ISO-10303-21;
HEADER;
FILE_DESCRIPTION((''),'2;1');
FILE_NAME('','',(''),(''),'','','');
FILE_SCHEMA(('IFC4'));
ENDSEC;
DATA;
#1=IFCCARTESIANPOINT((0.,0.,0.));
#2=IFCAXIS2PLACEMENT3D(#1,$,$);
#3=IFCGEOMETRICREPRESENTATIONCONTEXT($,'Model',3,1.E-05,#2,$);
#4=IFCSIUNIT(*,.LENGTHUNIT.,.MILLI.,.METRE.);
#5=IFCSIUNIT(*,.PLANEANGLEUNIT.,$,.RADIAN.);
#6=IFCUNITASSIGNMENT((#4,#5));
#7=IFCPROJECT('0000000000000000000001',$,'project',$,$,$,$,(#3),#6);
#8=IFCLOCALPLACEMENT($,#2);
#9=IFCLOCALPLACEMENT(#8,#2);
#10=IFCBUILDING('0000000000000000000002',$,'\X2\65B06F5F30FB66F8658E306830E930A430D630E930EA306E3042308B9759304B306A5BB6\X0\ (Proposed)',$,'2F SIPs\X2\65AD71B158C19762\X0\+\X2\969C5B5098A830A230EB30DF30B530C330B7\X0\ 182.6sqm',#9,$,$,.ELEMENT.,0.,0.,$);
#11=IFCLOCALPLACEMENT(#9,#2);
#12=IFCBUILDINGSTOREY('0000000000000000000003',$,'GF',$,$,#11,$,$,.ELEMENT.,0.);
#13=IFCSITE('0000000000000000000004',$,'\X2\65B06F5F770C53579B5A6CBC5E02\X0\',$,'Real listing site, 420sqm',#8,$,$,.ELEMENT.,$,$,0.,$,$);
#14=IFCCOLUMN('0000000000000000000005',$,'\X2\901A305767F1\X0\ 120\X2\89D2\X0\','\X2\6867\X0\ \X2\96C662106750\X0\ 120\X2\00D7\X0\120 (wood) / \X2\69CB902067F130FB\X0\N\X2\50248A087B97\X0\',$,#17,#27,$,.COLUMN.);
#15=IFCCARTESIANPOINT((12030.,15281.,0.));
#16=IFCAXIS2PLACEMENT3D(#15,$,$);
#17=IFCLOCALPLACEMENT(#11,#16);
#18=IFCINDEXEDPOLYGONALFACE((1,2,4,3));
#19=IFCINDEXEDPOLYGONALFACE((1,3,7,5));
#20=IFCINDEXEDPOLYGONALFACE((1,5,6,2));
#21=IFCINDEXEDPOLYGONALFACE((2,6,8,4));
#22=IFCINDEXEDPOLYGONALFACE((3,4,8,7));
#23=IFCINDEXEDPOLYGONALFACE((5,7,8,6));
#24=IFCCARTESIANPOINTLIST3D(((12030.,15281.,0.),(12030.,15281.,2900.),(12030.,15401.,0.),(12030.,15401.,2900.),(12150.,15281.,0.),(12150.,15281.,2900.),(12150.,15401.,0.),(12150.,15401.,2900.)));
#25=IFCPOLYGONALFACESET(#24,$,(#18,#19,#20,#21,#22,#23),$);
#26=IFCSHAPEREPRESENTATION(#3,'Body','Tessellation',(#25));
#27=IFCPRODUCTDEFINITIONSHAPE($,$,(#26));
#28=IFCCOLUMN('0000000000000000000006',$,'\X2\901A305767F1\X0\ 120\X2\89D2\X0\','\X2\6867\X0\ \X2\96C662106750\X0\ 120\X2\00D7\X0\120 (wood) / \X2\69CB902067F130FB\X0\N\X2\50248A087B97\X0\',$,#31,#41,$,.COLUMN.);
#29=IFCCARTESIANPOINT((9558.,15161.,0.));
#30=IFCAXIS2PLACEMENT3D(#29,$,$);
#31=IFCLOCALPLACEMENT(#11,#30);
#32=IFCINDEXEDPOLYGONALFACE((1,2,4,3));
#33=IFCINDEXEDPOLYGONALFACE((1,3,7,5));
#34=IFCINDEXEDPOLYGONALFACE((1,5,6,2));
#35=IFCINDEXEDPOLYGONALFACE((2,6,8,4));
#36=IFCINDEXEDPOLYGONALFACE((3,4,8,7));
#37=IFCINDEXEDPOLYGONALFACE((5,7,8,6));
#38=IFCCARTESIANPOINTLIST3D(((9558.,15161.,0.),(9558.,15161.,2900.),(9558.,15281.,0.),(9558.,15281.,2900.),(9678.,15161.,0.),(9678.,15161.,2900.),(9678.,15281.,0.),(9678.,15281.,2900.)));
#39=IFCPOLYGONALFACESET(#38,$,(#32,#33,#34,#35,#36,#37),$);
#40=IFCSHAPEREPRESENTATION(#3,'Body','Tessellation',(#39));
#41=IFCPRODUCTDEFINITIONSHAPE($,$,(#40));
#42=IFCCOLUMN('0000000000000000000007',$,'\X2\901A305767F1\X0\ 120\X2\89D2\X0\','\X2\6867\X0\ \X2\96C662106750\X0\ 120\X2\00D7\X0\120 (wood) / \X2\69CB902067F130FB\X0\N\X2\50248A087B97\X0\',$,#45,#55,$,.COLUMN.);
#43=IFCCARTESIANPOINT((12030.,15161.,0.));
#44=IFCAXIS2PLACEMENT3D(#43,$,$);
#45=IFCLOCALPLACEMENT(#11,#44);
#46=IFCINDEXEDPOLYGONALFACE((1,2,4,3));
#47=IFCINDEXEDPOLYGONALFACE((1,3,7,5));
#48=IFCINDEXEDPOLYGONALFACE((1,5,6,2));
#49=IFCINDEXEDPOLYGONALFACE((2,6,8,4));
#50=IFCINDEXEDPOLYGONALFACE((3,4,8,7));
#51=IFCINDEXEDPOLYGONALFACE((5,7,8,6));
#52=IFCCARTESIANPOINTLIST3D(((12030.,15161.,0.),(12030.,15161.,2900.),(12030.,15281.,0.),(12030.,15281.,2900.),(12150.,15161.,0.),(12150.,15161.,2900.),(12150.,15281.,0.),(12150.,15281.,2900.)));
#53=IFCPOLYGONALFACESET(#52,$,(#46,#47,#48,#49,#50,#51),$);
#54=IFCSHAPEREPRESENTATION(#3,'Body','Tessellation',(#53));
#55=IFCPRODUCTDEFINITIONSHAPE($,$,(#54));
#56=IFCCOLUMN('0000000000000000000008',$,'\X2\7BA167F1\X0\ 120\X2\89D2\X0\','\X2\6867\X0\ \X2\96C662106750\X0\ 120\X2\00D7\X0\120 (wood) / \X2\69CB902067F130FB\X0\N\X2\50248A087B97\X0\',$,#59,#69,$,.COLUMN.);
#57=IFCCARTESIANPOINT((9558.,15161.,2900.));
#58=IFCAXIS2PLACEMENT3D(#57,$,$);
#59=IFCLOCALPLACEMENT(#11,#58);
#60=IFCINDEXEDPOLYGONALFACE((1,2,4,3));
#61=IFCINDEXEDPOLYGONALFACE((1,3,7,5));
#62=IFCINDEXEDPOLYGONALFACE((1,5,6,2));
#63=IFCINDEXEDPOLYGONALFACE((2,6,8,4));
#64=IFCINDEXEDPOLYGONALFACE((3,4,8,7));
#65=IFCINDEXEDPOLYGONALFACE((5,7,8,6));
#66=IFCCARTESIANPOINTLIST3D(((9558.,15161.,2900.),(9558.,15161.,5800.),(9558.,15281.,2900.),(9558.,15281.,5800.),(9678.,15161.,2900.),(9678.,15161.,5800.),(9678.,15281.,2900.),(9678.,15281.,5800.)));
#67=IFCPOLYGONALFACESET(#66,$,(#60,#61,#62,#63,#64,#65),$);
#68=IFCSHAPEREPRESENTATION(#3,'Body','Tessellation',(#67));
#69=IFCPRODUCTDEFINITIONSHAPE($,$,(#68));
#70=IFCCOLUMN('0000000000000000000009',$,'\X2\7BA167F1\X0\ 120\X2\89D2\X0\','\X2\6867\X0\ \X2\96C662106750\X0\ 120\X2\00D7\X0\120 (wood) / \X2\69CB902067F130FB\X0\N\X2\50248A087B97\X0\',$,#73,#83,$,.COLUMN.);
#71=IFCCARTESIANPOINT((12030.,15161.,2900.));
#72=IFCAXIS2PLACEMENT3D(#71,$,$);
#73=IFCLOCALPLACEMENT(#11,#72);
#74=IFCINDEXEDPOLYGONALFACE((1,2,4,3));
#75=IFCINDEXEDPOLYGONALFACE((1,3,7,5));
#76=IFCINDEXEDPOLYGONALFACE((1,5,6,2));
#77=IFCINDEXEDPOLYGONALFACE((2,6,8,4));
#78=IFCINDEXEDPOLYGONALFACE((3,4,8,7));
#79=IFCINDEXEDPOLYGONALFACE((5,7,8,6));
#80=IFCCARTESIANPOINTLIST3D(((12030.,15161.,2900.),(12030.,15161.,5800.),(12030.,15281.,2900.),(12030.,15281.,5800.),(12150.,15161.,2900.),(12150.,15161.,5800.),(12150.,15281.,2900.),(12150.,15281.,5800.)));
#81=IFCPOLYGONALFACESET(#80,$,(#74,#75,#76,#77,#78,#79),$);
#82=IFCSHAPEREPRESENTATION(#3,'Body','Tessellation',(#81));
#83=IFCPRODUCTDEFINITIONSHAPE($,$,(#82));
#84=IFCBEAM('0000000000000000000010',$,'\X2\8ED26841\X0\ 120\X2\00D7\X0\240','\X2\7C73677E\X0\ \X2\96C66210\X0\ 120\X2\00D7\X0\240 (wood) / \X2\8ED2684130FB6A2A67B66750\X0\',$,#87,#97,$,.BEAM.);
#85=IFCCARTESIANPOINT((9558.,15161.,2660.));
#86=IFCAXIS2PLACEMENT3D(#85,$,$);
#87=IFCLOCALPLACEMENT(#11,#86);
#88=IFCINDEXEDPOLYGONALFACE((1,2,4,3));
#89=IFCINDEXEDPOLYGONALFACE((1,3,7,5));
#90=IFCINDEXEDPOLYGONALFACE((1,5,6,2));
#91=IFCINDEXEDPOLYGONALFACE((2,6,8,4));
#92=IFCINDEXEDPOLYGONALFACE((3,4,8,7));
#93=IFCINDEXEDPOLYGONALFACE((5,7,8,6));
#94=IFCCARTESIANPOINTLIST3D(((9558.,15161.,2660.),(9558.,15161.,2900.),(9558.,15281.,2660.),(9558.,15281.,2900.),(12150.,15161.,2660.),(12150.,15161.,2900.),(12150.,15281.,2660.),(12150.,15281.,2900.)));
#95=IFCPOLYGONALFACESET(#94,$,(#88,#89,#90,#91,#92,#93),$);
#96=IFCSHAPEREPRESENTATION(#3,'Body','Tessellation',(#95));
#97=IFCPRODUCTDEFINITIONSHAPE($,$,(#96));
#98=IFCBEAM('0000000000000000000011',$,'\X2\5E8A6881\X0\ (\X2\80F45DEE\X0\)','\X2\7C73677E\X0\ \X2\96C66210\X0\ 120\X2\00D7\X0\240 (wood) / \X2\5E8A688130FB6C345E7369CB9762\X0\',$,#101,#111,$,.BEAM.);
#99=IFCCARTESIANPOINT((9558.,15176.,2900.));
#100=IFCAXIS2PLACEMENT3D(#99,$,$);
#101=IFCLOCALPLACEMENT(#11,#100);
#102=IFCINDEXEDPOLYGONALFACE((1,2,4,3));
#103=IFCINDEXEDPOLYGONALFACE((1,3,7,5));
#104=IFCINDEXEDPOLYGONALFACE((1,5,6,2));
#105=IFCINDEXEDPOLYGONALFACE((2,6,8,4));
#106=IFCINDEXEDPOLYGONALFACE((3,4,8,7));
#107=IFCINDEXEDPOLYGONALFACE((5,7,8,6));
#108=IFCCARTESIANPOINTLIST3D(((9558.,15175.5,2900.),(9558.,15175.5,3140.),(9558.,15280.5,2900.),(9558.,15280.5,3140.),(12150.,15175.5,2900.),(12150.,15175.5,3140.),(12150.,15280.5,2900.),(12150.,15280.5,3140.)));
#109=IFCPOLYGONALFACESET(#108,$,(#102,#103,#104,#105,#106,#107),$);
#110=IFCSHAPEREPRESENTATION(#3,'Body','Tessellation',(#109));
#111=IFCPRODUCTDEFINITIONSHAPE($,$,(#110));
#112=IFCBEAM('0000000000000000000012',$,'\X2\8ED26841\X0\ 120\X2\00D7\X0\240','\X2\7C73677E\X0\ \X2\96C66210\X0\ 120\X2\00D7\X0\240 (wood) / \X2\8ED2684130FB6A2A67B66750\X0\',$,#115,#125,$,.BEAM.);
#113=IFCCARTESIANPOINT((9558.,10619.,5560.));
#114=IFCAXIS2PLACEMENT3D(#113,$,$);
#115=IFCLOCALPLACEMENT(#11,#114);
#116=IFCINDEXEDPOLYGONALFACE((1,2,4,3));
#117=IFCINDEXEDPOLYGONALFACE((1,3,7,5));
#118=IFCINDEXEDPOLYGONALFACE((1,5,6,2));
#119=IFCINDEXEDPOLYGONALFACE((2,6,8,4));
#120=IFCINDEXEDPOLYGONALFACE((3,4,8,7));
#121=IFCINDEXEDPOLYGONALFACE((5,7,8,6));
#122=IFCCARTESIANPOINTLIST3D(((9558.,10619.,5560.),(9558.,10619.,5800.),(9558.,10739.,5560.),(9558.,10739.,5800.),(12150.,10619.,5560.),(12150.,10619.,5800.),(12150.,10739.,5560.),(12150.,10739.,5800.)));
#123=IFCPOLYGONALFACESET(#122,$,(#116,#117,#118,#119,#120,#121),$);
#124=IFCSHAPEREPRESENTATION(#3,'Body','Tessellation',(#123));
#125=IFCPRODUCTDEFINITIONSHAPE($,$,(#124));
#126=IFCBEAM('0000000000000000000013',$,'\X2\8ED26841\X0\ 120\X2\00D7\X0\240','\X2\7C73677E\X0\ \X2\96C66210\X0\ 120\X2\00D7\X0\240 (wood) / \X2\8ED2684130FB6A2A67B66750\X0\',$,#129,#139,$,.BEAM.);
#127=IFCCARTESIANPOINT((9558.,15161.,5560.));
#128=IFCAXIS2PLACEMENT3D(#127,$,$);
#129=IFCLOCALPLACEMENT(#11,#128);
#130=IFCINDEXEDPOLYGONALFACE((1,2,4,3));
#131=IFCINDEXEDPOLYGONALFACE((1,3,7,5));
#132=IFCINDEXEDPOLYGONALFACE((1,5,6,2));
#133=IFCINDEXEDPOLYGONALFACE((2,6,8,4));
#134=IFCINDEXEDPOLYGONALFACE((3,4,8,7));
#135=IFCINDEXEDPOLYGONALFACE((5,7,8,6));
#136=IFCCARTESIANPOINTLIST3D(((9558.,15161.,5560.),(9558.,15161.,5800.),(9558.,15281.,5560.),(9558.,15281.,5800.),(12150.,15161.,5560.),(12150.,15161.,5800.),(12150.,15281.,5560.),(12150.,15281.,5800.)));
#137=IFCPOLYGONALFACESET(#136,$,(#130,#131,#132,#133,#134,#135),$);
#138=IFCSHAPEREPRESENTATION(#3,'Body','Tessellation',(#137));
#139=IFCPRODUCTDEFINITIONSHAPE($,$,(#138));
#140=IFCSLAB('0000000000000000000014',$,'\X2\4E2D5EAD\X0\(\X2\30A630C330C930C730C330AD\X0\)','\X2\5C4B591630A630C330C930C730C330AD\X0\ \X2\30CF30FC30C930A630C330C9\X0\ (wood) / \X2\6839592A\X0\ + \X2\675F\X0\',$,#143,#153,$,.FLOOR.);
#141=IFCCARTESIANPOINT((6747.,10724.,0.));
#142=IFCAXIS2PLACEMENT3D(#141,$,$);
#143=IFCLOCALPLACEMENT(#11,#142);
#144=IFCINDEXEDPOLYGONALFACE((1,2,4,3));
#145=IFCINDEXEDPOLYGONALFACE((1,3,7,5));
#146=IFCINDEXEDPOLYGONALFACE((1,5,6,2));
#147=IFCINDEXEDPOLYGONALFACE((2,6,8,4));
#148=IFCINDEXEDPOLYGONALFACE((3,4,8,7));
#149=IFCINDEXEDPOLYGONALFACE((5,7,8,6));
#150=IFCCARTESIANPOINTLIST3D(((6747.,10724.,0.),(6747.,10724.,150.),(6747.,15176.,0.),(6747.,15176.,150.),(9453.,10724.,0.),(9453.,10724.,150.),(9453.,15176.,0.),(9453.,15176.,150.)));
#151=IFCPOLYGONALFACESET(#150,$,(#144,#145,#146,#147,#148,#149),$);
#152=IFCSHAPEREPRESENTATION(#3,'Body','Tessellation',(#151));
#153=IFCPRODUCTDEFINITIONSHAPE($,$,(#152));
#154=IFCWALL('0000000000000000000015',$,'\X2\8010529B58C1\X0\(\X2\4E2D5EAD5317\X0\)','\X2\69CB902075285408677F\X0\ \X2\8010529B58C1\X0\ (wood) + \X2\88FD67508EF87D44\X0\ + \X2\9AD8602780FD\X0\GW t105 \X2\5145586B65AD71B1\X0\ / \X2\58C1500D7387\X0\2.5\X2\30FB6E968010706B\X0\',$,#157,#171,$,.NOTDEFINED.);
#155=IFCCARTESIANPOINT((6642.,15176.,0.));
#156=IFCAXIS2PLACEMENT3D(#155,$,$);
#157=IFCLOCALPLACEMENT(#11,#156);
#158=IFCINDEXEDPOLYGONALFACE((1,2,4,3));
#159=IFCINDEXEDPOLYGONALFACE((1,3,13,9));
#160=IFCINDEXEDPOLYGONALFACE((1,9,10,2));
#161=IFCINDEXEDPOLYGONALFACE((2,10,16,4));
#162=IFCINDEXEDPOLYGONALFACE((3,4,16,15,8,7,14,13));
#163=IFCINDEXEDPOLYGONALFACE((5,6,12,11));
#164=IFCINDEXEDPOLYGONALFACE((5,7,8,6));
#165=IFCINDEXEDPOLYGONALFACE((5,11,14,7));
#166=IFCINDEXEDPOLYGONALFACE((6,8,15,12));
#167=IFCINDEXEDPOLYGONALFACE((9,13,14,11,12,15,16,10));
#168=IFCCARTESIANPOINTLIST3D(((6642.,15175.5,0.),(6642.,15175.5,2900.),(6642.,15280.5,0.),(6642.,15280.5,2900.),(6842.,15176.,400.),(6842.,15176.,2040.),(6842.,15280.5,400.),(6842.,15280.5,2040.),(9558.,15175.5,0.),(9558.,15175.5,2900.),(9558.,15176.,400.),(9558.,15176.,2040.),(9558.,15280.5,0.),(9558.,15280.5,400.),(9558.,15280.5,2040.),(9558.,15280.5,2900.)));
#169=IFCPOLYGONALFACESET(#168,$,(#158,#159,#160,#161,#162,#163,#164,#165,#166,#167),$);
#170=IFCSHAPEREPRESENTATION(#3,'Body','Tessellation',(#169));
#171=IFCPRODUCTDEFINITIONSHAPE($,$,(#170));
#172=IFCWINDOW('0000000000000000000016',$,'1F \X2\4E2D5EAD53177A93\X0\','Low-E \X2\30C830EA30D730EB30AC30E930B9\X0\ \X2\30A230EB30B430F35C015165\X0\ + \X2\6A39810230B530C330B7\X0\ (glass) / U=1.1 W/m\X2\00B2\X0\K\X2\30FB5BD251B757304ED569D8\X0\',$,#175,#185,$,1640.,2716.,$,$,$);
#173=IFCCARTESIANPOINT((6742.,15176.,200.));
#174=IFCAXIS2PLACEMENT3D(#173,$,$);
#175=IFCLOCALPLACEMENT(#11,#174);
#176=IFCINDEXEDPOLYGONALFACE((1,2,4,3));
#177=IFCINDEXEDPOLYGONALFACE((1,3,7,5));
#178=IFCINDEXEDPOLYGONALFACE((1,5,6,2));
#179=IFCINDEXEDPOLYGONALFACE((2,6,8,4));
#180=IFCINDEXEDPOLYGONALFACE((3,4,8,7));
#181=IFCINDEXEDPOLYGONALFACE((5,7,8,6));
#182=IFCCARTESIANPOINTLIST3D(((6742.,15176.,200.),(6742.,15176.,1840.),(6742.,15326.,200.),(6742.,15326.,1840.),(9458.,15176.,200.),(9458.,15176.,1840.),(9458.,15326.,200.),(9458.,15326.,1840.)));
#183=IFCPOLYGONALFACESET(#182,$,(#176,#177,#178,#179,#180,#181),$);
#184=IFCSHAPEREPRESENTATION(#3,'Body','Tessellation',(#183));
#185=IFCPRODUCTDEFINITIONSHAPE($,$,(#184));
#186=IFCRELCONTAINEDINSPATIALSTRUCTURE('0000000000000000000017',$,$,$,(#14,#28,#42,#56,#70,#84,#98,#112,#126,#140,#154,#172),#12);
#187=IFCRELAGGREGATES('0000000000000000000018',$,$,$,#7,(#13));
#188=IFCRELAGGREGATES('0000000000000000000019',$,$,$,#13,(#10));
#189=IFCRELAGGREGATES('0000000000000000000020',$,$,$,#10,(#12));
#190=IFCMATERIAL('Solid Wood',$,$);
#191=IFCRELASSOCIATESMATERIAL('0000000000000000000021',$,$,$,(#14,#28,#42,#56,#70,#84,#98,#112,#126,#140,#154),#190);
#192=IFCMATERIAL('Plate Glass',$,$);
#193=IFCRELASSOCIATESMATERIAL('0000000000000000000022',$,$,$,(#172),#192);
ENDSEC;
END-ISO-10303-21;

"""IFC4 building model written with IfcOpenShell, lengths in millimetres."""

from ifc_helpers import new_model, si_unit, frame, frame_2d, origin, place, context, project, spatial, rectangle, extrude, material, element, fill, save


model = new_model("IFC4")

# Units and contexts
model_context = context("Model", 3, precision=1e-05, world=origin())
ifc_project = project(units=[si_unit("LENGTHUNIT", "METRE", prefix="MILLI"), si_unit("PLANEANGLEUNIT", "RADIAN")], contexts=[model_context])

# Site, building, storey
site_placement = place(None, origin())
site = spatial("IfcSite", under=ifc_project, at=site_placement, Name="新潟県南魚沼市", ObjectType="Real listing site, 420sqm", CompositionType="ELEMENT", RefElevation=0.0)
building_placement = place(site_placement, origin())
building = spatial("IfcBuilding", under=site, at=building_placement, Name="新潟・書斎とライブラリのある静かな家 (Proposed)", ObjectType="2F SIPs断熱壁面+障子風アルミサッシ 182.6sqm", CompositionType="ELEMENT", ElevationOfRefHeight=0.0, ElevationOfTerrain=0.0)
storey_placement = place(building_placement, origin())
storey = spatial("IfcBuildingStorey", under=building, at=storey_placement, Name="GF", CompositionType="ELEMENT", Elevation=0.0)

# Columns
ifc_material_1 = material(Name="Solid Wood")
column_1_placement = place(storey_placement, frame((12030.0, 15281.0, 0.0)))
element("IfcColumn", 1, at=column_1_placement, inside=storey, material=ifc_material_1, Name="通し柱 120角", Description="桧 集成材 120×120 (wood) / 構造柱・N値計算", PredefinedType="COLUMN", context=model_context, shape_type="SweptSolid", body=[
    extrude(rectangle(XDim=120.0, YDim=120.0, at=frame_2d((60.0, 60.0))), frame((12030.0, 15281.0, 0.0)), (0.0, 0.0, 1.0), 2900.0),
])
column_2_placement = place(storey_placement, frame((9558.0, 15161.0, 0.0)))
element("IfcColumn", 2, at=column_2_placement, inside=storey, material=ifc_material_1, Name="通し柱 120角", Description="桧 集成材 120×120 (wood) / 構造柱・N値計算", PredefinedType="COLUMN", context=model_context, shape_type="SweptSolid", body=[
    extrude(rectangle(XDim=120.0, YDim=120.0, at=frame_2d((60.0, 60.0))), frame((9558.0, 15161.0, 0.0)), (0.0, 0.0, 1.0), 2900.0),
])
column_3_placement = place(storey_placement, frame((12030.0, 15161.0, 0.0)))
element("IfcColumn", 3, at=column_3_placement, inside=storey, material=ifc_material_1, Name="通し柱 120角", Description="桧 集成材 120×120 (wood) / 構造柱・N値計算", PredefinedType="COLUMN", context=model_context, shape_type="SweptSolid", body=[
    extrude(rectangle(XDim=120.0, YDim=120.0, at=frame_2d((60.0, 60.0))), frame((12030.0, 15161.0, 0.0)), (0.0, 0.0, 1.0), 2900.0),
])
column_4_placement = place(storey_placement, frame((9558.0, 15161.0, 2900.0)))
element("IfcColumn", 4, at=column_4_placement, inside=storey, material=ifc_material_1, Name="管柱 120角", Description="桧 集成材 120×120 (wood) / 構造柱・N値計算", PredefinedType="COLUMN", context=model_context, shape_type="SweptSolid", body=[
    extrude(rectangle(XDim=120.0, YDim=120.0, at=frame_2d((60.0, 60.0))), frame((9558.0, 15161.0, 2900.0)), (0.0, 0.0, 1.0), 2900.0),
])
column_5_placement = place(storey_placement, frame((12030.0, 15161.0, 2900.0)))
element("IfcColumn", 5, at=column_5_placement, inside=storey, material=ifc_material_1, Name="管柱 120角", Description="桧 集成材 120×120 (wood) / 構造柱・N値計算", PredefinedType="COLUMN", context=model_context, shape_type="SweptSolid", body=[
    extrude(rectangle(XDim=120.0, YDim=120.0, at=frame_2d((60.0, 60.0))), frame((12030.0, 15161.0, 2900.0)), (0.0, 0.0, 1.0), 2900.0),
])

# Beams
beam_1_placement = place(storey_placement, frame((9558.0, 15161.0, 2660.0)))
element("IfcBeam", 6, at=beam_1_placement, inside=storey, material=ifc_material_1, Name="軒桁 120×240", Description="米松 集成 120×240 (wood) / 軒桁・横架材", PredefinedType="BEAM", context=model_context, shape_type="SweptSolid", body=[
    extrude(rectangle(XDim=2592.0, YDim=120.0, at=frame_2d((1296.0, 60.0))), frame((9558.0, 15161.0, 2660.0)), (0.0, 0.0, 1.0), 240.0),
])
beam_2_placement = place(storey_placement, frame((9558.0, 15176.0, 2900.0)))
element("IfcBeam", 7, at=beam_2_placement, inside=storey, material=ifc_material_1, Name="床梁 (胴差)", Description="米松 集成 120×240 (wood) / 床梁・水平構面", PredefinedType="BEAM", context=model_context, shape_type="SweptSolid", body=[
    extrude(rectangle(XDim=2592.0, YDim=105.0, at=frame_2d((1296.0, 52.0))), frame((9558.0, 15176.0, 2900.0)), (0.0, 0.0, 1.0), 240.0),
])
beam_3_placement = place(storey_placement, frame((9558.0, 10619.0, 5560.0)))
element("IfcBeam", 8, at=beam_3_placement, inside=storey, material=ifc_material_1, Name="軒桁 120×240", Description="米松 集成 120×240 (wood) / 軒桁・横架材", PredefinedType="BEAM", context=model_context, shape_type="SweptSolid", body=[
    extrude(rectangle(XDim=2592.0, YDim=120.0, at=frame_2d((1296.0, 60.0))), frame((9558.0, 10619.0, 5560.0)), (0.0, 0.0, 1.0), 240.0),
])
beam_4_placement = place(storey_placement, frame((9558.0, 15161.0, 5560.0)))
element("IfcBeam", 9, at=beam_4_placement, inside=storey, material=ifc_material_1, Name="軒桁 120×240", Description="米松 集成 120×240 (wood) / 軒桁・横架材", PredefinedType="BEAM", context=model_context, shape_type="SweptSolid", body=[
    extrude(rectangle(XDim=2592.0, YDim=120.0, at=frame_2d((1296.0, 60.0))), frame((9558.0, 15161.0, 5560.0)), (0.0, 0.0, 1.0), 240.0),
])

# Slab
slab_placement = place(storey_placement, frame((6747.0, 10724.0, 0.0)))
element("IfcSlab", 10, at=slab_placement, inside=storey, material=ifc_material_1, Name="中庭(ウッドデッキ)", Description="屋外ウッドデッキ ハードウッド (wood) / 根太 + 束", PredefinedType="FLOOR", context=model_context, shape_type="SweptSolid", body=[
    extrude(rectangle(XDim=2706.0, YDim=4452.0, at=frame_2d((1353.0, 2226.0))), frame((6747.0, 10724.0, 0.0)), (0.0, 0.0, 1.0), 150.0),
])

# Wall, opening, window
wall_1_placement = place(storey_placement, frame((6642.0, 15176.0, 0.0)))
wall_1 = element("IfcWall", 11, at=wall_1_placement, inside=storey, material=ifc_material_1, Name="耐力壁(中庭北)", Description="構造用合板 耐力壁 (wood) + 製材軸組 + 高性能GW t105 充填断熱 / 壁倍率2.5・準耐火", PredefinedType="NOTDEFINED", context=model_context, shape_type="SweptSolid", body=[
    extrude(rectangle(XDim=2916.0, YDim=105.0, at=frame_2d((1458.0, 52.0))), frame((6642.0, 15176.0, 0.0)), (0.0, 0.0, 1.0), 2900.0),
])
opening_1_placement = place(storey_placement, frame((6742.0, 15176.0, 200.0)))
opening_1 = element("IfcOpeningElement", 12, at=opening_1_placement, cuts=wall_1, PredefinedType="NOTDEFINED", context=model_context, shape_type="SweptSolid", body=[
    extrude(rectangle(XDim=2716.0, YDim=150.0, at=frame_2d((1358.0, 75.0))), frame((6742.0, 15176.0, 200.0)), (0.0, 0.0, 1.0), 1640.0),
])
ifc_material_2 = material(Name="Plate Glass")
window_1_placement = place(storey_placement, frame((6742.0, 15176.0, 200.0)))
window_1 = element("IfcWindow", 13, at=window_1_placement, inside=storey, material=ifc_material_2, Name="1F 中庭北窓", Description="Low-E トリプルガラス アルゴン封入 + 樹脂サッシ (glass) / U=1.1 W/m²K・寒冷地仕様", OverallHeight=1640.0, OverallWidth=2716.0, context=model_context, shape_type="SweptSolid", body=[
    extrude(rectangle(XDim=2716.0, YDim=150.0, at=frame_2d((1358.0, 75.0))), frame((6742.0, 15176.0, 200.0)), (0.0, 0.0, 1.0), 1640.0),
])
fill(opening_1, window_1)

save(model, "model.ifc")
